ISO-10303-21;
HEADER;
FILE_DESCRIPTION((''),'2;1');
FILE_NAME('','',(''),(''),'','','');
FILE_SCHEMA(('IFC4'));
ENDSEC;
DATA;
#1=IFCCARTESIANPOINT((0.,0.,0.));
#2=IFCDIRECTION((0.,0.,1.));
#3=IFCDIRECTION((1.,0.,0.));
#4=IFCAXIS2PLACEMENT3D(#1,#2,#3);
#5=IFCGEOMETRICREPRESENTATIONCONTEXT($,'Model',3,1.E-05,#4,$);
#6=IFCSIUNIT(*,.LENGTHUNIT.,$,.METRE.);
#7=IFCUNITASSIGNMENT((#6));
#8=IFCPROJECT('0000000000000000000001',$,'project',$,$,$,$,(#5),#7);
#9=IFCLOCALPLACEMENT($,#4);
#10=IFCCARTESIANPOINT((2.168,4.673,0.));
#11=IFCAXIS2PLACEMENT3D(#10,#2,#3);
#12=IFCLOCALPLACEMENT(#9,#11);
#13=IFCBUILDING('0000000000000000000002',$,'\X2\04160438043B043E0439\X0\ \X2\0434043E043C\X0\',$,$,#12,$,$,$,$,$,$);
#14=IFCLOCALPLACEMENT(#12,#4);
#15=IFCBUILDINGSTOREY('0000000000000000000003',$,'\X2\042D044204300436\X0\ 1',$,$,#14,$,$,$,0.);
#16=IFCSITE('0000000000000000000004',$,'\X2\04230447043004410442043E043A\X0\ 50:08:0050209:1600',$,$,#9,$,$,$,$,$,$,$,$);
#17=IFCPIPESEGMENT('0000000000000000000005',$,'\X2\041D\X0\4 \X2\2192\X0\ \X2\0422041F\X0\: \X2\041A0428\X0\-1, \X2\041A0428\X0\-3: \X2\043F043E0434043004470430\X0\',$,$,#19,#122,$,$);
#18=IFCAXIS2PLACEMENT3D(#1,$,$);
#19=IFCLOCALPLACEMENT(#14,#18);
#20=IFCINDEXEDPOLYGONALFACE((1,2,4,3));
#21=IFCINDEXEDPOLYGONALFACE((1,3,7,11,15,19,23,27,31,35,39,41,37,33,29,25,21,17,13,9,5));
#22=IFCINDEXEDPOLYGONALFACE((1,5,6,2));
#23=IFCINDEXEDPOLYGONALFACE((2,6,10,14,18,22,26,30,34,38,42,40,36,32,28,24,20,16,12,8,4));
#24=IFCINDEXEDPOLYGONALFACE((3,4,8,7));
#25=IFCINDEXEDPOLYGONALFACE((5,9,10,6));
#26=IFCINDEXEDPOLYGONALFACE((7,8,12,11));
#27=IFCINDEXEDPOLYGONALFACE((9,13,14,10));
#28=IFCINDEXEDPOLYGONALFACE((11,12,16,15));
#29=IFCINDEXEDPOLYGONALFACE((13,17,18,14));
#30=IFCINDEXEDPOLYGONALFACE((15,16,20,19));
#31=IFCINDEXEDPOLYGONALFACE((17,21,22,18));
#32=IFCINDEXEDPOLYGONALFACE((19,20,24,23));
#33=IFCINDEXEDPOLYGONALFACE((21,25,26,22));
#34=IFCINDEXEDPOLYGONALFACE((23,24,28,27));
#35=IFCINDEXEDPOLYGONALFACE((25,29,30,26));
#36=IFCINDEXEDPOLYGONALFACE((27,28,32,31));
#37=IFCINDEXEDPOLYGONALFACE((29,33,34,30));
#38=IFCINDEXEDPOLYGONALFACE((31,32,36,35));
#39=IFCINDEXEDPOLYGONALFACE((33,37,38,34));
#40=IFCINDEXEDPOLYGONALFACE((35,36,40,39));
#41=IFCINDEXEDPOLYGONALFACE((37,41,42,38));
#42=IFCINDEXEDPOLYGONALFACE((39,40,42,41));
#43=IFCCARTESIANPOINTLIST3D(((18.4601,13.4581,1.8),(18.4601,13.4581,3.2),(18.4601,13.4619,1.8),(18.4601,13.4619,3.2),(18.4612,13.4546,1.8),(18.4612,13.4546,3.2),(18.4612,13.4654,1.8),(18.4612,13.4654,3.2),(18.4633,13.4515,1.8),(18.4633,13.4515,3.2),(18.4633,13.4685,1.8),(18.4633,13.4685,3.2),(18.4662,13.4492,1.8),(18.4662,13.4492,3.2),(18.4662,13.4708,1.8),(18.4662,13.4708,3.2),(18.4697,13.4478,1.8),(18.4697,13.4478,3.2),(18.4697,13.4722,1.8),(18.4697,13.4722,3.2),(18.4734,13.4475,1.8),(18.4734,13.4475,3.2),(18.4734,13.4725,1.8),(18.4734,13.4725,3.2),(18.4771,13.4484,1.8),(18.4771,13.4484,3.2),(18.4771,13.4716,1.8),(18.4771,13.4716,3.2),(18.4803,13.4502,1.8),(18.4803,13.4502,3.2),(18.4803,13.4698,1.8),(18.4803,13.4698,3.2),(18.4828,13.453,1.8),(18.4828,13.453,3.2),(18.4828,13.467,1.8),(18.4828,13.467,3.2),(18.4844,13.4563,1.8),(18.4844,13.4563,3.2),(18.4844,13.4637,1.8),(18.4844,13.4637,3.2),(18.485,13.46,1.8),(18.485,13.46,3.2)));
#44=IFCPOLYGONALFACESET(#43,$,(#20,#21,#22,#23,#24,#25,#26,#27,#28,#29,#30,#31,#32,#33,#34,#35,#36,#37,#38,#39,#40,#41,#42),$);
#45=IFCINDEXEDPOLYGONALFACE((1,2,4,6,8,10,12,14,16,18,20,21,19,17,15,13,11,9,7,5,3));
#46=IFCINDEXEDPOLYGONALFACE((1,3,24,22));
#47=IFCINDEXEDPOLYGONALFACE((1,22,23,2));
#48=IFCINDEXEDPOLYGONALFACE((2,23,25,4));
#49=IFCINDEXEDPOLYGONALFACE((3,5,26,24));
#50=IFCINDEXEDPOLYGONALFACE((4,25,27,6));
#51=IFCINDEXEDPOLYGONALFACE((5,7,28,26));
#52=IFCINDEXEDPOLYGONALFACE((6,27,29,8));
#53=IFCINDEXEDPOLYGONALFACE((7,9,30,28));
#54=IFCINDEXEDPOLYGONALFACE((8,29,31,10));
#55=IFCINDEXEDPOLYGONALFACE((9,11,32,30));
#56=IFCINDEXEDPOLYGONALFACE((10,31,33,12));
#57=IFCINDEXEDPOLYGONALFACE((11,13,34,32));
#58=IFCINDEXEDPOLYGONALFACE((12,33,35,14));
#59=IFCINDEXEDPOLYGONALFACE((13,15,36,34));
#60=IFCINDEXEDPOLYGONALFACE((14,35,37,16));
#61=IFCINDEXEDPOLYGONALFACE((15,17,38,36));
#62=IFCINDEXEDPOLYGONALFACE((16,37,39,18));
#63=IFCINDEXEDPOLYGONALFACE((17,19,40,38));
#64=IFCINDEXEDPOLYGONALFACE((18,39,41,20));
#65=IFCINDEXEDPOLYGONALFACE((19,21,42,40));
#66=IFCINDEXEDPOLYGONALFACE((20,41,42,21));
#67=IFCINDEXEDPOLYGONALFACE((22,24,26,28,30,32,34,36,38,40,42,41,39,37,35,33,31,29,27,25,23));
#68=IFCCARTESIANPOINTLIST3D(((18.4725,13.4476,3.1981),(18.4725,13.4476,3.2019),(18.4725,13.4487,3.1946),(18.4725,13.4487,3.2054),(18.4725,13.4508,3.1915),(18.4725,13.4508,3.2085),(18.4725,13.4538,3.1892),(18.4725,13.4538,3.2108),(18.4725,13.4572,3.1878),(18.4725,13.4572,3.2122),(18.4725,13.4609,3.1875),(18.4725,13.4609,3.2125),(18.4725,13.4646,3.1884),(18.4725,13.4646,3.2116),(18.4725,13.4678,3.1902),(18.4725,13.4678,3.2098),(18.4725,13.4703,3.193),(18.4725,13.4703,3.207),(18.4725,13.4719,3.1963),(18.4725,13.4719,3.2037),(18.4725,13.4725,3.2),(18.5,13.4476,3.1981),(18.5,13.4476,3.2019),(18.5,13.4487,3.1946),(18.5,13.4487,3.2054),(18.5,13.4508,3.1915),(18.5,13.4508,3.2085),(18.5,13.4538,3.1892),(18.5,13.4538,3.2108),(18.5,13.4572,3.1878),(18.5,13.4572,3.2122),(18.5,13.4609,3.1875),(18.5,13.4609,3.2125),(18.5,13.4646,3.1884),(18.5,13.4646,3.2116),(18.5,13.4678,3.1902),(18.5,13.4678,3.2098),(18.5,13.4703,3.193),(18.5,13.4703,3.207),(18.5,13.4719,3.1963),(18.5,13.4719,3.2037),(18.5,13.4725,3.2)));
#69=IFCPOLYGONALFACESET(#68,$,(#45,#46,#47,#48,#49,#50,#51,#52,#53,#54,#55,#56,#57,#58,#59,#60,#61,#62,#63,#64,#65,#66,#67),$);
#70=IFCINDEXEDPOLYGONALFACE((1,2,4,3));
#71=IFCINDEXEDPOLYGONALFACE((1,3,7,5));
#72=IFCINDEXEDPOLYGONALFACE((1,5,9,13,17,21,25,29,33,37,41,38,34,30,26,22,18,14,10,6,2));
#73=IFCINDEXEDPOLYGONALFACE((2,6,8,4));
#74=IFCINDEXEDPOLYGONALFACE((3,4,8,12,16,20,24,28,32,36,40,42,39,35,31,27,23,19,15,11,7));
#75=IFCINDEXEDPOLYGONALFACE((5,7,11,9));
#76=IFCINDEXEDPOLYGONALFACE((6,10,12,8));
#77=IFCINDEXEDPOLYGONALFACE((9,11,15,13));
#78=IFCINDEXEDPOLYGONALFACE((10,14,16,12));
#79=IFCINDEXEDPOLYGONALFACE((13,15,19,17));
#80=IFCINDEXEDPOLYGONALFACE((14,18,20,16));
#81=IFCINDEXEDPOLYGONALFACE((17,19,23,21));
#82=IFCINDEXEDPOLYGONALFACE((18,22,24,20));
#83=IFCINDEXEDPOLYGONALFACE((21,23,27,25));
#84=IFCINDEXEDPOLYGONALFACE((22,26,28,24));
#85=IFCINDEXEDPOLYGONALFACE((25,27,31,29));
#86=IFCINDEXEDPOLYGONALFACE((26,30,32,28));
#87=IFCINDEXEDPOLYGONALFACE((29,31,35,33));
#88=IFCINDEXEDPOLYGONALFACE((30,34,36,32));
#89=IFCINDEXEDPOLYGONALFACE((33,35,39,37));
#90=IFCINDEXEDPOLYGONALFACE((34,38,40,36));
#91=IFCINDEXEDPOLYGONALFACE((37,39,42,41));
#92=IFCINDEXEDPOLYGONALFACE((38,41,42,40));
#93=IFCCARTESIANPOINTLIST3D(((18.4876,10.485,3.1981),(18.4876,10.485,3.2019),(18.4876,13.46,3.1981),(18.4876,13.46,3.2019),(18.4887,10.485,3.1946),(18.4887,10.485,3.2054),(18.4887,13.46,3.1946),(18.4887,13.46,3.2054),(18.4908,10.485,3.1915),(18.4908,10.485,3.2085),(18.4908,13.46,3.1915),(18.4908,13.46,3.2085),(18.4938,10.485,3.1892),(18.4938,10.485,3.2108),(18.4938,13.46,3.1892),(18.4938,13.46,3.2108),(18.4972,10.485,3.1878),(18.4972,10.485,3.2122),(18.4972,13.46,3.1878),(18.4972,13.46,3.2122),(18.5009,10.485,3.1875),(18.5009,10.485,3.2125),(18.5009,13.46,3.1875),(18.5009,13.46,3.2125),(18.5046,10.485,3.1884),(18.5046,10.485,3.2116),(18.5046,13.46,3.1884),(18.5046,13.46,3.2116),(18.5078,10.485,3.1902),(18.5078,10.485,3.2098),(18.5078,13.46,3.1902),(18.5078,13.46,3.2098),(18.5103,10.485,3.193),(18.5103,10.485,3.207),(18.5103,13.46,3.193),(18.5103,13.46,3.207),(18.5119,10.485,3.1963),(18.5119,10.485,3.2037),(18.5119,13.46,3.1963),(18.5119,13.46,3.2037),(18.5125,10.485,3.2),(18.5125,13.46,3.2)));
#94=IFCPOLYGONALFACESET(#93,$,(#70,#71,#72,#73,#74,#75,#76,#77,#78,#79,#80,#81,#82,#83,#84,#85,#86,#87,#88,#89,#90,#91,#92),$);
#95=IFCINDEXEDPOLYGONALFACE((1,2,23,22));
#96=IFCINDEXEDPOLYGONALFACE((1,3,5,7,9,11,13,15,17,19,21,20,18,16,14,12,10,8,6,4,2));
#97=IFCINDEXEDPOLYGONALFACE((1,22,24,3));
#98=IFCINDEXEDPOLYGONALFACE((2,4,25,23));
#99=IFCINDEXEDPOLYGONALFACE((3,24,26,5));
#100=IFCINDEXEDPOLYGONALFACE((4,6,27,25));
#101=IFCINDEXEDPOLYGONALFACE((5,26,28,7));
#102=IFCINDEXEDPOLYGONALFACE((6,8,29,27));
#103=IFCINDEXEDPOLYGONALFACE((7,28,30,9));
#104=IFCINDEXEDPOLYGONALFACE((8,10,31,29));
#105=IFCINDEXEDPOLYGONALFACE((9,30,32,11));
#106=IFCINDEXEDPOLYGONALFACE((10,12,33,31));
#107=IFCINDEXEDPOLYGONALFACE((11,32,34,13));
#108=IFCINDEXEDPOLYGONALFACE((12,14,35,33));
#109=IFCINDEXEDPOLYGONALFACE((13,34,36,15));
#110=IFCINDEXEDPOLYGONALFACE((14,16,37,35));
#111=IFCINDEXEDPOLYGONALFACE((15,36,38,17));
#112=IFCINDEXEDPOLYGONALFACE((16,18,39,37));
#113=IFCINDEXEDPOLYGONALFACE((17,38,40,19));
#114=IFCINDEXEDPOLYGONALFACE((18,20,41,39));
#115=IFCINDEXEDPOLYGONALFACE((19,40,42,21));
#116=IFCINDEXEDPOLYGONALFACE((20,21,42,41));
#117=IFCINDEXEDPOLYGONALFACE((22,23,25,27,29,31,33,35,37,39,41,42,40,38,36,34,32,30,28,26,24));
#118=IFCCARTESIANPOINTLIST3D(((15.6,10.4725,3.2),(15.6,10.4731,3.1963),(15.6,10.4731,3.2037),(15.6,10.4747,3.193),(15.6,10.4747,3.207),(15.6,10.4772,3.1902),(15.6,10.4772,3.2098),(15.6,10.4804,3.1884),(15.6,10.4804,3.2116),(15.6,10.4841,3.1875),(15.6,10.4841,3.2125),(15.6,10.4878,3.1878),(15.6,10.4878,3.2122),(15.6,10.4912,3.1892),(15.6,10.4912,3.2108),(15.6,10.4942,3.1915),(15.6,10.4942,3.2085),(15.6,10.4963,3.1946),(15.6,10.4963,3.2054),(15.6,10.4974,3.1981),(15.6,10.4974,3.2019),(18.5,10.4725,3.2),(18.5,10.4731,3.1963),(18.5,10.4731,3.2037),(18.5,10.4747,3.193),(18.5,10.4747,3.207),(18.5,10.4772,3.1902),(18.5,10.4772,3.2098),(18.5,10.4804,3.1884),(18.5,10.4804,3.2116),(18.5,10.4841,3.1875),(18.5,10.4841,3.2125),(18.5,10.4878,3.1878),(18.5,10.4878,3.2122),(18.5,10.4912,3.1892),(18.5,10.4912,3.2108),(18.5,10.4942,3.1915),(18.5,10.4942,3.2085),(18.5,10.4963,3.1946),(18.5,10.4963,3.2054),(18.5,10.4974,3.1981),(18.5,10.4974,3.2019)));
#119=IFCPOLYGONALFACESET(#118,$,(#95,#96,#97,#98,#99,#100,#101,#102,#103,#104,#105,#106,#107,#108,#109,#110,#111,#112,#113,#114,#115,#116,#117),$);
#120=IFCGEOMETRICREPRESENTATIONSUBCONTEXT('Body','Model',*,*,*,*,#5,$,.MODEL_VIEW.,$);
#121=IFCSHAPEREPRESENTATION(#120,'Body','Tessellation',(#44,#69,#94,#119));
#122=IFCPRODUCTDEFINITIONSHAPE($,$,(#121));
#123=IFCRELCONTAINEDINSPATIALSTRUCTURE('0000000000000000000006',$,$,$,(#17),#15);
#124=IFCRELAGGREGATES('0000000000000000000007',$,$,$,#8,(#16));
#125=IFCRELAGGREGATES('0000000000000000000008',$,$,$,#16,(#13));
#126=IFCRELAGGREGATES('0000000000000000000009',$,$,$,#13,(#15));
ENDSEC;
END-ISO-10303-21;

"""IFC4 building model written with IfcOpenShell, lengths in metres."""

from ifc_helpers import new_model, si_unit, frame, origin_with_axes, origin_2d, place, context, subcontext, project, spatial, circle, extrude, element, save


model = new_model("IFC4")

# Units and contexts
model_context = context("Model", 3, precision=1e-05, world=origin_with_axes())
body_context = subcontext(model_context, "Body", "Model", "MODEL_VIEW")
ifc_project = project(units=[si_unit("LENGTHUNIT", "METRE")], contexts=[model_context])

# Site, building, storey
site_placement = place(None, origin_with_axes())
site = spatial("IfcSite", under=ifc_project, at=site_placement, Name="Участок 50:08:0050209:1600")
building_placement = place(site_placement, frame((2.168, 4.673, 0.0), z_axis=(0.0, 0.0, 1.0), x_axis=(1.0, 0.0, 0.0)))
building = spatial("IfcBuilding", under=site, at=building_placement, Name="Жилой дом")
storey_placement = place(building_placement, origin_with_axes())
storey = spatial("IfcBuildingStorey", under=building, at=storey_placement, Name="Этаж 1", Elevation=0.0)

# Pipe segment
pipe_segment_1_placement = place(storey_placement, origin_with_axes())
element("IfcPipeSegment", 1, at=pipe_segment_1_placement, inside=storey, Name="Н4 → ТП: КШ-1, КШ-3: подача", context=body_context, shape_type="SweptSolid", body=[
    extrude(circle(Radius=0.0125, at=origin_2d()), frame((18.4725, 13.46, 1.8), z_axis=(0.0, 0.0, 1.0), x_axis=(1.0, 0.0, 0.0)), (0.0, 0.0, 1.0), 1.4),
    extrude(circle(Radius=0.0125, at=origin_2d()), frame((18.4725, 13.46, 3.2), z_axis=(1.0, 0.0, 0.0), x_axis=(0.0, 1.0, 0.0)), (0.0, 0.0, 1.0), 0.0275),
    extrude(circle(Radius=0.0125, at=origin_2d()), frame((18.5, 13.46, 3.2), z_axis=(0.0, -1.0, 0.0), x_axis=(1.0, 0.0, 0.0)), (0.0, 0.0, 1.0), 2.975),
    extrude(circle(Radius=0.0125, at=origin_2d()), frame((18.5, 10.485, 3.2), z_axis=(-1.0, 0.0, 0.0), x_axis=(0.0, -1.0, 0.0)), (0.0, 0.0, 1.0), 2.9),
])

save(model, "model.ifc")
